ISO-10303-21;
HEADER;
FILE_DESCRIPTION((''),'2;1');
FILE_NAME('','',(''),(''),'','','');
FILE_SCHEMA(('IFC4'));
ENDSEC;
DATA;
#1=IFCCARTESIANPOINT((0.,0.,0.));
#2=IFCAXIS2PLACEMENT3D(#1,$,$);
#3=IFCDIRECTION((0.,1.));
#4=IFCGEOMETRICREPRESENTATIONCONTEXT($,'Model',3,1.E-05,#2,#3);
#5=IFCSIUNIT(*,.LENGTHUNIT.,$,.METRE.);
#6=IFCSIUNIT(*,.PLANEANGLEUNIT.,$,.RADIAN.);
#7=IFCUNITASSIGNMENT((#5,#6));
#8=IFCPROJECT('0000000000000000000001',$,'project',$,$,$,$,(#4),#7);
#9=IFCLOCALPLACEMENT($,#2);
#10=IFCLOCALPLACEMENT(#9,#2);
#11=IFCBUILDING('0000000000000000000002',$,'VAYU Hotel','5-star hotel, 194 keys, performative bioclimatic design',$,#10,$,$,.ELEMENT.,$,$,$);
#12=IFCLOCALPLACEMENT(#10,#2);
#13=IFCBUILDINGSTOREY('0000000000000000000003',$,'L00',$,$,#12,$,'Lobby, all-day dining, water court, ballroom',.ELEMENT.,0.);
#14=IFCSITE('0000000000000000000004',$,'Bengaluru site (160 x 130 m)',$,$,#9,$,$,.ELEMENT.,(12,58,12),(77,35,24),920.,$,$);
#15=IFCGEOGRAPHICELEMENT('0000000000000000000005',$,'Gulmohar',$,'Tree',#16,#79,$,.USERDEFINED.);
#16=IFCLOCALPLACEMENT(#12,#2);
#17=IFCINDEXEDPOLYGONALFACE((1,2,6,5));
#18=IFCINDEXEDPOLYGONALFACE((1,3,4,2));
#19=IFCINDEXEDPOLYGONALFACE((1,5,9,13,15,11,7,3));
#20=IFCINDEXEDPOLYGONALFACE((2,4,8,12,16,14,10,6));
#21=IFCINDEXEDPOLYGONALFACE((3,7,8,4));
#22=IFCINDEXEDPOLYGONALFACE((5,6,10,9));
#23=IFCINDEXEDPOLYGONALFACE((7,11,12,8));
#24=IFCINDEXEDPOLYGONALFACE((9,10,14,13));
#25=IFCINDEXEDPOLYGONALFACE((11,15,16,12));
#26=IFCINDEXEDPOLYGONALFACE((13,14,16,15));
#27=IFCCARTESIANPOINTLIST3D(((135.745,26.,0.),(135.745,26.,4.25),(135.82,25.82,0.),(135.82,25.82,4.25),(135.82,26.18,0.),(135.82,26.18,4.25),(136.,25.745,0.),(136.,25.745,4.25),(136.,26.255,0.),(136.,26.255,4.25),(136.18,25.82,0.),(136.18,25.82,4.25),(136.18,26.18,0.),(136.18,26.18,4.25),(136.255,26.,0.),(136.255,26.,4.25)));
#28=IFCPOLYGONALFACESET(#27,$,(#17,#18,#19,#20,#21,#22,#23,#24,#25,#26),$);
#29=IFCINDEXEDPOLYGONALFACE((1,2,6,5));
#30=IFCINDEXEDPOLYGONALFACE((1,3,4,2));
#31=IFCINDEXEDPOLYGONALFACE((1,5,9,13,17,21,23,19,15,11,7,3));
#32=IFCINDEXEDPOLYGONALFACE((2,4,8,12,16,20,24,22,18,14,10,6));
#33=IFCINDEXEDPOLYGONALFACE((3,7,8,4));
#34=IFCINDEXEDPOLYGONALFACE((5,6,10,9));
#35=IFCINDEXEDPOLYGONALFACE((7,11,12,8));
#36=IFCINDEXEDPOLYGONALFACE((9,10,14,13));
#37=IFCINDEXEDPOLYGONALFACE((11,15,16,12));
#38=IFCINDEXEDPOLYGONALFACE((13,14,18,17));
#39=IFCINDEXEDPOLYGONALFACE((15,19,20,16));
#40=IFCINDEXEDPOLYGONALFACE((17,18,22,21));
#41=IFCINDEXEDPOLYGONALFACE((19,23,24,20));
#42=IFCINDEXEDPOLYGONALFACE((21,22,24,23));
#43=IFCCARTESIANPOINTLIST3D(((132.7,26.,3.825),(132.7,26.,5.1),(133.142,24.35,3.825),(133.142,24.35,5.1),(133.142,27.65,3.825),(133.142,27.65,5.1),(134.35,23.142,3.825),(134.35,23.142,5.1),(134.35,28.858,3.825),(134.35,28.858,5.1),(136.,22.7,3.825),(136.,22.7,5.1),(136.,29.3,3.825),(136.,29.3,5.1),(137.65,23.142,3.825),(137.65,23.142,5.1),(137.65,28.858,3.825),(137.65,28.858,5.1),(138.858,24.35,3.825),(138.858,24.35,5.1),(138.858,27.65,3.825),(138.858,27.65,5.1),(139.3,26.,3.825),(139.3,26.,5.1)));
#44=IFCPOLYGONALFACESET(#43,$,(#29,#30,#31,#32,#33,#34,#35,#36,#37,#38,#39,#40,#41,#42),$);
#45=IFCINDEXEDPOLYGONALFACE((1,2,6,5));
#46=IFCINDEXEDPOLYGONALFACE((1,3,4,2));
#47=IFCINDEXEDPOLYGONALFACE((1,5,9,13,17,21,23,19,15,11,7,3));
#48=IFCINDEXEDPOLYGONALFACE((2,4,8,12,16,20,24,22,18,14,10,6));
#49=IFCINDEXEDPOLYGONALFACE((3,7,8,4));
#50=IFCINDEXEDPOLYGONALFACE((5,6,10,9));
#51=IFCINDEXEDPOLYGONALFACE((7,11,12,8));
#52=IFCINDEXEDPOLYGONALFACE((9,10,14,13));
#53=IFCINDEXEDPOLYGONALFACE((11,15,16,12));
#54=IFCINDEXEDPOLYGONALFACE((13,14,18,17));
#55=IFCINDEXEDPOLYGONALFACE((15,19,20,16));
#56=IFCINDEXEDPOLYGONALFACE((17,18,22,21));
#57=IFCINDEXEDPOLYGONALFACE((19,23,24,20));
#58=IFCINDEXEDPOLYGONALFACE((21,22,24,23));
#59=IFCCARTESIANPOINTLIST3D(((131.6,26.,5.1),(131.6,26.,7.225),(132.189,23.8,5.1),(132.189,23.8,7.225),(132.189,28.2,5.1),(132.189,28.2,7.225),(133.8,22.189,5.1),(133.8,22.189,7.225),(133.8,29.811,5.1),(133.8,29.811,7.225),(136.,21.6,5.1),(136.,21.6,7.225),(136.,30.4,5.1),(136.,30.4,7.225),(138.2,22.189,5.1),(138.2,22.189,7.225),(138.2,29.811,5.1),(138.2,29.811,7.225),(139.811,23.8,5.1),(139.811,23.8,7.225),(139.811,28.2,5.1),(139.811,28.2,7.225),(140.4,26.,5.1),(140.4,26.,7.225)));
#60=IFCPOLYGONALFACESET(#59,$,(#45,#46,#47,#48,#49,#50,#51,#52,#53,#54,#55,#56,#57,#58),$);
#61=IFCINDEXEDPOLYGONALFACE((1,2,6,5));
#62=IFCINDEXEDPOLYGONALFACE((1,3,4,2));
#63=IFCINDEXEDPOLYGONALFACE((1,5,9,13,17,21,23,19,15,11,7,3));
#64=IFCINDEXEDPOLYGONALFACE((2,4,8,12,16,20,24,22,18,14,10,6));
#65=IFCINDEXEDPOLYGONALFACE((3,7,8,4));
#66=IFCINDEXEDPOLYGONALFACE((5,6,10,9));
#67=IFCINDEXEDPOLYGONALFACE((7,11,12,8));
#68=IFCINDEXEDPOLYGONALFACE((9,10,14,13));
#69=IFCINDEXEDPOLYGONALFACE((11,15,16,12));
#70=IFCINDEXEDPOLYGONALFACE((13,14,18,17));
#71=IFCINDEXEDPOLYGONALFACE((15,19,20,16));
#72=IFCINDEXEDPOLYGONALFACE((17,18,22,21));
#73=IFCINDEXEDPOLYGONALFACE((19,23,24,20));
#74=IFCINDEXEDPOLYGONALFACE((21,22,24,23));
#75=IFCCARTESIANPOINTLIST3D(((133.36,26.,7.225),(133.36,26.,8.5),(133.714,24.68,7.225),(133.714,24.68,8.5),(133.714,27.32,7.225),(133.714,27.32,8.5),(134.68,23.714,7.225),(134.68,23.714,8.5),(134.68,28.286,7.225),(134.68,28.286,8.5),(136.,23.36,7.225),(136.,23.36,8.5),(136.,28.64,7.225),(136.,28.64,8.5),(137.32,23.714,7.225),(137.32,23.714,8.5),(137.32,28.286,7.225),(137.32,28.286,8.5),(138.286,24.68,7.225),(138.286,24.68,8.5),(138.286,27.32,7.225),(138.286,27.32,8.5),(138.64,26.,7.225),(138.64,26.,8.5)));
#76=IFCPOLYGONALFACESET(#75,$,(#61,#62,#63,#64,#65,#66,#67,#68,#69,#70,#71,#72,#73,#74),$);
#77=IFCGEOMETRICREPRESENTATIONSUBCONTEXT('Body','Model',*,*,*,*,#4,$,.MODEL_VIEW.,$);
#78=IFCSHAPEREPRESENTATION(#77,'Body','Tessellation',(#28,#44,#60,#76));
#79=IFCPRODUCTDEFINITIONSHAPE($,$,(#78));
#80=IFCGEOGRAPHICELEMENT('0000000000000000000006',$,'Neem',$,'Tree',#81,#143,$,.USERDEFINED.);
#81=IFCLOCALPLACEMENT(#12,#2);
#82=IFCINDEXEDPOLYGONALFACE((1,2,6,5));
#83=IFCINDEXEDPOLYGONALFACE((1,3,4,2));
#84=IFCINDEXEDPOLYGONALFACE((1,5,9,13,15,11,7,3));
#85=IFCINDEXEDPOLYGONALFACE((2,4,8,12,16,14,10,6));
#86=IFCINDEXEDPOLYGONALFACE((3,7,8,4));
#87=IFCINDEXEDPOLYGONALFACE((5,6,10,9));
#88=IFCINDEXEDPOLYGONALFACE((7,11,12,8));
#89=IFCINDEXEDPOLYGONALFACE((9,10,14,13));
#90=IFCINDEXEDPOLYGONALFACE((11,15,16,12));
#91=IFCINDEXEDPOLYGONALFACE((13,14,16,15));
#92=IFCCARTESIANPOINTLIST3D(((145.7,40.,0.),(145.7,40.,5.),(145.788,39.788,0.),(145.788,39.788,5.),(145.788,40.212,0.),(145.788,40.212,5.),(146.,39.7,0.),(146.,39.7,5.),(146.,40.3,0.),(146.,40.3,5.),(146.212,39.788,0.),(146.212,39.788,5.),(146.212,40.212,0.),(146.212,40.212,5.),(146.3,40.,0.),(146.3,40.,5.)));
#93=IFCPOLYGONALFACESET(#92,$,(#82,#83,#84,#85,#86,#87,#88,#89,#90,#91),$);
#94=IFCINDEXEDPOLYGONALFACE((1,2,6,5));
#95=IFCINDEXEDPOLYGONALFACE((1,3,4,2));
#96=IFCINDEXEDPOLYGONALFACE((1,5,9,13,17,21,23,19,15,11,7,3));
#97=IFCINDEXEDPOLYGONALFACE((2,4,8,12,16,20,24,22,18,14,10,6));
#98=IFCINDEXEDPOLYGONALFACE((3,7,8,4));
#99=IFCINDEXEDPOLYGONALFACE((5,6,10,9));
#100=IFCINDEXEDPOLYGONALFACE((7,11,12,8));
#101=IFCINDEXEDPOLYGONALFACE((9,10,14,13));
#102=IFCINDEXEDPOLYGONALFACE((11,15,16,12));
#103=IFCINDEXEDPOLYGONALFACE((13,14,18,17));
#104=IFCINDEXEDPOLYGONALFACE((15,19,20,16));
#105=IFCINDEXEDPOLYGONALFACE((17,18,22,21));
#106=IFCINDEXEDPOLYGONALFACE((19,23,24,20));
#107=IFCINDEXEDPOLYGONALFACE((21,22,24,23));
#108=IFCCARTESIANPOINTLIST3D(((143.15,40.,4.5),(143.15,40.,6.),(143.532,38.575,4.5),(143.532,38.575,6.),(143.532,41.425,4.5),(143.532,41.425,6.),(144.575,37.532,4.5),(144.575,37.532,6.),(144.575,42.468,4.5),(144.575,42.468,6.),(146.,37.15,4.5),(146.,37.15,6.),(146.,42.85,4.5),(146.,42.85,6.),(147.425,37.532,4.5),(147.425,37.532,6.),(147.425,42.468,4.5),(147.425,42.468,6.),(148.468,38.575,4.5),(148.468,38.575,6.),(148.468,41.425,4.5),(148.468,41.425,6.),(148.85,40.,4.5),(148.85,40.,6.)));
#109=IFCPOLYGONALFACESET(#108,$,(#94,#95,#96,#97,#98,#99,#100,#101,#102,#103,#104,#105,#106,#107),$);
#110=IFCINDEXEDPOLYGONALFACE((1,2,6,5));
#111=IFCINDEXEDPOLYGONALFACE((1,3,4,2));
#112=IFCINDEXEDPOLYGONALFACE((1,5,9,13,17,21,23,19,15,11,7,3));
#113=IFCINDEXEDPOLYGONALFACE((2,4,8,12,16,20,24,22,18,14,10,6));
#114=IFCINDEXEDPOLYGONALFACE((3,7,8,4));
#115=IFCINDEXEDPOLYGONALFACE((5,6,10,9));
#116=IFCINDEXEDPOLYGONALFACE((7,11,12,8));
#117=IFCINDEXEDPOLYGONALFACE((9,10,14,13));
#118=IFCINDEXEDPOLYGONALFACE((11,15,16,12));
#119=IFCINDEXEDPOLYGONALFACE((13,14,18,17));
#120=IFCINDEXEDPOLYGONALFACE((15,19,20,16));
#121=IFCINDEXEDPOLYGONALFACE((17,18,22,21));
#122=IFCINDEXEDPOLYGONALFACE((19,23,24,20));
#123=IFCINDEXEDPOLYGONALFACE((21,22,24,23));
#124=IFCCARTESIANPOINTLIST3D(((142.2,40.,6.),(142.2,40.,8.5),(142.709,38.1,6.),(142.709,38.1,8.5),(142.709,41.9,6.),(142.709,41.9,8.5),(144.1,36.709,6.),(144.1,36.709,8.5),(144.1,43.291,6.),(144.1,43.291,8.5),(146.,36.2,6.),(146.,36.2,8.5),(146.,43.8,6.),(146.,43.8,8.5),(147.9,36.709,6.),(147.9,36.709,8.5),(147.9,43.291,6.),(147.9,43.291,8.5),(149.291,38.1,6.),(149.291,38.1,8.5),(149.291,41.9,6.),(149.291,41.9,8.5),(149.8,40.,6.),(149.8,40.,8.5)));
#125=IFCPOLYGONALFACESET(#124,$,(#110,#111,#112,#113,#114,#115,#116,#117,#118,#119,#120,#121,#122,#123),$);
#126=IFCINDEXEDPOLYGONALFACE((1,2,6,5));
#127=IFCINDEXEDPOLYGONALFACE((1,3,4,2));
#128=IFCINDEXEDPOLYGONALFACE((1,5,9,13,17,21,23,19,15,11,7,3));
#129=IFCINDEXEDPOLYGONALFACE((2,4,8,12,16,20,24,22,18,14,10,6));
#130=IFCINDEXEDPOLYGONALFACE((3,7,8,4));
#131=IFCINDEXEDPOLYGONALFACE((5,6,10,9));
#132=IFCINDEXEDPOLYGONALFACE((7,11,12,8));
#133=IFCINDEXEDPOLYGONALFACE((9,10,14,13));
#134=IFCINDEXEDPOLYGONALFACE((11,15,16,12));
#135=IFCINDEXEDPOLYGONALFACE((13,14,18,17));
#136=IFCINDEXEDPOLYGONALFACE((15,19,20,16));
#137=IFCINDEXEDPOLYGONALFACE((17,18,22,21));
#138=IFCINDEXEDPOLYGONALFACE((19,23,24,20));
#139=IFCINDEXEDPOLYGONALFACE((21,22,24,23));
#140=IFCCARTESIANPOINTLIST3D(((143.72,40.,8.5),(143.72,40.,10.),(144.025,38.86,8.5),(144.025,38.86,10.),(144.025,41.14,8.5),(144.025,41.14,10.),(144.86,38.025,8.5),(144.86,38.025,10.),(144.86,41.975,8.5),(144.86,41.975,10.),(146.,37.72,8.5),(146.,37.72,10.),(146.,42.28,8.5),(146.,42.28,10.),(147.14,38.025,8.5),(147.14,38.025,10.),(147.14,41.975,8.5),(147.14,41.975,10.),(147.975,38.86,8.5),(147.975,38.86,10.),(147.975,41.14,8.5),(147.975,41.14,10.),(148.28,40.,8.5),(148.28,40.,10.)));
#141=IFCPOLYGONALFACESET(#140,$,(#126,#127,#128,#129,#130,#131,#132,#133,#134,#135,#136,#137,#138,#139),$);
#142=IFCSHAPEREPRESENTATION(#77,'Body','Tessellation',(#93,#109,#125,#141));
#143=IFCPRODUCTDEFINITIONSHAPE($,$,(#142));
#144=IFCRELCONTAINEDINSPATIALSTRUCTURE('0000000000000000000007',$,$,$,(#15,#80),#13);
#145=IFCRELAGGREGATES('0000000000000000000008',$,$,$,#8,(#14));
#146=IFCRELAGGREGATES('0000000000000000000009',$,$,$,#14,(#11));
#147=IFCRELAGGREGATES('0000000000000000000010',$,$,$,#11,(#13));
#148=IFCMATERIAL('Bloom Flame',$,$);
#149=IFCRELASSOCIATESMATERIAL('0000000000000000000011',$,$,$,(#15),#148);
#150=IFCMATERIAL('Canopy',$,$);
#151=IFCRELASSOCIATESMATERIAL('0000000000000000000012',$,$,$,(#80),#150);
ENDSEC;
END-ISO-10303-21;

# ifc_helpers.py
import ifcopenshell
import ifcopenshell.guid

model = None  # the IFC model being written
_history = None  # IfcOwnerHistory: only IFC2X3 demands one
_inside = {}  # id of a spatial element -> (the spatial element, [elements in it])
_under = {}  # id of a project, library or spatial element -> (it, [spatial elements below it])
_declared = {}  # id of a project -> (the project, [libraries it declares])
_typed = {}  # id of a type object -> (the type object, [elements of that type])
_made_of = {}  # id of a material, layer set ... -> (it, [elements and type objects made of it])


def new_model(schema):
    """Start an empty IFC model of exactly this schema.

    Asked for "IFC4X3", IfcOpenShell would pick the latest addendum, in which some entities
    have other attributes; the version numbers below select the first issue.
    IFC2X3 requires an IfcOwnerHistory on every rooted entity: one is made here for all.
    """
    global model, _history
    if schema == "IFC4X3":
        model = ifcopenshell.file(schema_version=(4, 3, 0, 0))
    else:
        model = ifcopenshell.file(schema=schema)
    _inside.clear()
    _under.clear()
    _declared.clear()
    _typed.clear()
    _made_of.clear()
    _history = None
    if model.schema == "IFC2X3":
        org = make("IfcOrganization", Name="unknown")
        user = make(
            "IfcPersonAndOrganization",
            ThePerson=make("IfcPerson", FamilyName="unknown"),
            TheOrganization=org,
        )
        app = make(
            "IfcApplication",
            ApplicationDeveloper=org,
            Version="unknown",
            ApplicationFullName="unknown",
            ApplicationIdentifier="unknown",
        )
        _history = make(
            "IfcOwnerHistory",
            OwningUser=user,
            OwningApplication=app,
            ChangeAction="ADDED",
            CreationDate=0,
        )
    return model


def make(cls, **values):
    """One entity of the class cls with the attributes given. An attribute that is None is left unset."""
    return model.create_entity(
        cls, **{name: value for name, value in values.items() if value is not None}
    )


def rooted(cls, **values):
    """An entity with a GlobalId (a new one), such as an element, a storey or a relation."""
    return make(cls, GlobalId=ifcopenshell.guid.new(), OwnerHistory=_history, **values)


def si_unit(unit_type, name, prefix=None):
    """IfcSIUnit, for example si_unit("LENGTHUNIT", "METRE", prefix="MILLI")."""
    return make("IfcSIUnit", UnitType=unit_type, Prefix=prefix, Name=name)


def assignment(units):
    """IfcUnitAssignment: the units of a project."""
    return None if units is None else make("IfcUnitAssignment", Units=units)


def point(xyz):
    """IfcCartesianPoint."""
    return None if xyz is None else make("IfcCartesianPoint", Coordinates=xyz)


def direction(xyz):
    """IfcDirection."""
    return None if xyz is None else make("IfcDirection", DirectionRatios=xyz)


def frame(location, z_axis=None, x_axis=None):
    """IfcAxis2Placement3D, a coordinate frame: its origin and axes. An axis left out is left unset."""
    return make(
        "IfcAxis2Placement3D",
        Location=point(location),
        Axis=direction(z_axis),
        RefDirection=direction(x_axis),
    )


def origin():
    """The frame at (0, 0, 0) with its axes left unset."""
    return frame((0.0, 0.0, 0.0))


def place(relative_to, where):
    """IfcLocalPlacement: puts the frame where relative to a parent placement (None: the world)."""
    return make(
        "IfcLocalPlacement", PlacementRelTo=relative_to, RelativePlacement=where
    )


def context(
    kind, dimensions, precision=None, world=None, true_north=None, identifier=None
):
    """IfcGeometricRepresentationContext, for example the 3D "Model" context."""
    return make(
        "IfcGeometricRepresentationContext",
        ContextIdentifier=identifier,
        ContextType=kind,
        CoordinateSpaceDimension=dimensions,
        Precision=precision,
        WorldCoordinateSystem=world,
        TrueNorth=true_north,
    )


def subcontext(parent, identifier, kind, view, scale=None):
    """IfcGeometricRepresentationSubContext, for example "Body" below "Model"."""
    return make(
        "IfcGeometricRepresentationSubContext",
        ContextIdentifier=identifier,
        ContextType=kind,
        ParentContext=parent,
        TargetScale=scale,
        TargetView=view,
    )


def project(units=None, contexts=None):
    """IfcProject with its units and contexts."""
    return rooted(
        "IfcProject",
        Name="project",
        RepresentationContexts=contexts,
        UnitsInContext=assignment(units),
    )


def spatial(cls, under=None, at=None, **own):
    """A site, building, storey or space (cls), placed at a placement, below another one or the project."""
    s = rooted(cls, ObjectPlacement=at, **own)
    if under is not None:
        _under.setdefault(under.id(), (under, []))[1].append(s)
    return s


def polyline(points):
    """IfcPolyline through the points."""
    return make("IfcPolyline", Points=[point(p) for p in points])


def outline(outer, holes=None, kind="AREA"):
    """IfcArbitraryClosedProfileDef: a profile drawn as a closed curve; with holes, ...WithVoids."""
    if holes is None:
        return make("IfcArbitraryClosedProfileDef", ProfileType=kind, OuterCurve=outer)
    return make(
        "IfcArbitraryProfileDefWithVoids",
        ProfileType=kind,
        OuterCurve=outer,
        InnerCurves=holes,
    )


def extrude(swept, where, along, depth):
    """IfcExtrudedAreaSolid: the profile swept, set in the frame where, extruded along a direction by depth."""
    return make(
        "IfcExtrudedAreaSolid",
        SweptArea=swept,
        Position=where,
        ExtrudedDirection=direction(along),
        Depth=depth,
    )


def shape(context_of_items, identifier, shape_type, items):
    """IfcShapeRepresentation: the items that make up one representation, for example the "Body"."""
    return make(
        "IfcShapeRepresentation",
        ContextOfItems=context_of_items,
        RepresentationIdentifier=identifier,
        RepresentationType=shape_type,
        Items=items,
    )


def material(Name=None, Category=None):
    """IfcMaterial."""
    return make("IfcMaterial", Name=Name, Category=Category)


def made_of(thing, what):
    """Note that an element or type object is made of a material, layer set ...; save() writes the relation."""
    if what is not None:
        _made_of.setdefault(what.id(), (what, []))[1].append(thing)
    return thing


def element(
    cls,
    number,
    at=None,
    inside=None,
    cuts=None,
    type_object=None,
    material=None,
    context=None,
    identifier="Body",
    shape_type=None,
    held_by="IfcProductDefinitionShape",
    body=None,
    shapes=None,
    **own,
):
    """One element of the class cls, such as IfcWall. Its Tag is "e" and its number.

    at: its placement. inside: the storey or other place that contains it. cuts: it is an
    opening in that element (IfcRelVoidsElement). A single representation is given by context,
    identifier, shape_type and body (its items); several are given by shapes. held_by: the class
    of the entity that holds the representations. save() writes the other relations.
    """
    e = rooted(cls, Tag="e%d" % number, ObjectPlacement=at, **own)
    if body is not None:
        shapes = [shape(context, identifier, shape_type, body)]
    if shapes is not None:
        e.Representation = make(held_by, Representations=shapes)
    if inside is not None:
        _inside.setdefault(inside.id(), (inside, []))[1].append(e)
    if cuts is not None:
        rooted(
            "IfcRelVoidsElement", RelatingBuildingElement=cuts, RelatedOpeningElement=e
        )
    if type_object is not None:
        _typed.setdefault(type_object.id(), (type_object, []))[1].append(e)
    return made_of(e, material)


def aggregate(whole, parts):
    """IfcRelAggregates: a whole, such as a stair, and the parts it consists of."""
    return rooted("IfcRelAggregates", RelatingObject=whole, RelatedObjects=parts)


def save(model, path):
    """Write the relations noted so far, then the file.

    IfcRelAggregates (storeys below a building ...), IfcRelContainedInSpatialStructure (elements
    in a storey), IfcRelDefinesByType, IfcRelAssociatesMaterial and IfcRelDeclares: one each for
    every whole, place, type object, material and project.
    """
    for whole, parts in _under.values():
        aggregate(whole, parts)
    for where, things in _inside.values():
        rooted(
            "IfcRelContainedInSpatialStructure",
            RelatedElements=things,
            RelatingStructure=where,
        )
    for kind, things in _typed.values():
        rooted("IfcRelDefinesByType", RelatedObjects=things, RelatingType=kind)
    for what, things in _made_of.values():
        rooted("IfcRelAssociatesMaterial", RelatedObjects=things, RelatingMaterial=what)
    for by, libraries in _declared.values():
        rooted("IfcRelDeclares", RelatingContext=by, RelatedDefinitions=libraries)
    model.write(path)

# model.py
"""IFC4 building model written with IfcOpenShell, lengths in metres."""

from ifc_helpers import new_model, si_unit, direction, frame, origin, place, context, subcontext, project, spatial, polyline, outline, extrude, material, element, save


model = new_model("IFC4")

# Units and contexts
model_context = context("Model", 3, precision=1e-05, world=origin(), true_north=direction((0.0, 1.0)))
body_context = subcontext(model_context, "Body", "Model", "MODEL_VIEW")
ifc_project = project(units=[si_unit("LENGTHUNIT", "METRE"), si_unit("PLANEANGLEUNIT", "RADIAN")], contexts=[model_context])

# Site, building, storey
site_placement = place(None, origin())
site = spatial("IfcSite", under=ifc_project, at=site_placement, Name="Bengaluru site (160 x 130 m)", CompositionType="ELEMENT", RefLatitude=(12, 58, 12), RefLongitude=(77, 35, 24), RefElevation=920.0)
building_placement = place(site_placement, origin())
building = spatial("IfcBuilding", under=site, at=building_placement, Name="VAYU Hotel", Description="5-star hotel, 194 keys, performative bioclimatic design", CompositionType="ELEMENT")
storey_placement = place(building_placement, origin())
storey = spatial("IfcBuildingStorey", under=building, at=storey_placement, Name="L00", LongName="Lobby, all-day dining, water court, ballroom", CompositionType="ELEMENT", Elevation=0.0)

# Geographic elements
ifc_material_1 = material(Name="Canopy")
ifc_material_2 = material(Name="Bloom Flame")
geographic_element_1_placement = place(storey_placement, origin())
element("IfcGeographicElement", 1, at=geographic_element_1_placement, inside=storey, material=ifc_material_2, Name="Gulmohar", ObjectType="Tree", PredefinedType="USERDEFINED", context=body_context, shape_type="SweptSolid", body=[
    extrude(outline(polyline([(136.255, 26.0), (136.18, 26.18), (136.0, 26.255), (135.82, 26.18), (135.745, 26.0), (135.82, 25.82), (136.0, 25.745), (136.18, 25.82), (136.255, 26.0)])), origin(), (0.0, 0.0, 1.0), 4.25),
    extrude(outline(polyline([(139.3, 26.0), (138.858, 27.65), (137.65, 28.858), (136.0, 29.3), (134.35, 28.858), (133.142, 27.65), (132.7, 26.0), (133.142, 24.35), (134.35, 23.142), (136.0, 22.7), (137.65, 23.142), (138.858, 24.35), (139.3, 26.0)])), frame((0.0, 0.0, 3.825)), (0.0, 0.0, 1.0), 1.275),
    extrude(outline(polyline([(140.4, 26.0), (139.811, 28.2), (138.2, 29.811), (136.0, 30.4), (133.8, 29.811), (132.189, 28.2), (131.6, 26.0), (132.189, 23.8), (133.8, 22.189), (136.0, 21.6), (138.2, 22.189), (139.811, 23.8), (140.4, 26.0)])), frame((0.0, 0.0, 5.1)), (0.0, 0.0, 1.0), 2.125),
    extrude(outline(polyline([(138.64, 26.0), (138.286, 27.32), (137.32, 28.286), (136.0, 28.64), (134.68, 28.286), (133.714, 27.32), (133.36, 26.0), (133.714, 24.68), (134.68, 23.714), (136.0, 23.36), (137.32, 23.714), (138.286, 24.68), (138.64, 26.0)])), frame((0.0, 0.0, 7.225)), (0.0, 0.0, 1.0), 1.275),
])
geographic_element_2_placement = place(storey_placement, origin())
element("IfcGeographicElement", 2, at=geographic_element_2_placement, inside=storey, material=ifc_material_1, Name="Neem", ObjectType="Tree", PredefinedType="USERDEFINED", context=body_context, shape_type="SweptSolid", body=[
    extrude(outline(polyline([(146.3, 40.0), (146.212, 40.212), (146.0, 40.3), (145.788, 40.212), (145.7, 40.0), (145.788, 39.788), (146.0, 39.7), (146.212, 39.788), (146.3, 40.0)])), origin(), (0.0, 0.0, 1.0), 5.0),
    extrude(outline(polyline([(148.85, 40.0), (148.468, 41.425), (147.425, 42.468), (146.0, 42.85), (144.575, 42.468), (143.532, 41.425), (143.15, 40.0), (143.532, 38.575), (144.575, 37.532), (146.0, 37.15), (147.425, 37.532), (148.468, 38.575), (148.85, 40.0)])), frame((0.0, 0.0, 4.5)), (0.0, 0.0, 1.0), 1.5),
    extrude(outline(polyline([(149.8, 40.0), (149.291, 41.9), (147.9, 43.291), (146.0, 43.8), (144.1, 43.291), (142.709, 41.9), (142.2, 40.0), (142.709, 38.1), (144.1, 36.709), (146.0, 36.2), (147.9, 36.709), (149.291, 38.1), (149.8, 40.0)])), frame((0.0, 0.0, 6.0)), (0.0, 0.0, 1.0), 2.5),
    extrude(outline(polyline([(148.28, 40.0), (147.975, 41.14), (147.14, 41.975), (146.0, 42.28), (144.86, 41.975), (144.025, 41.14), (143.72, 40.0), (144.025, 38.86), (144.86, 38.025), (146.0, 37.72), (147.14, 38.025), (147.975, 38.86), (148.28, 40.0)])), frame((0.0, 0.0, 8.5)), (0.0, 0.0, 1.0), 1.5),
])

save(model, "model.ifc")
